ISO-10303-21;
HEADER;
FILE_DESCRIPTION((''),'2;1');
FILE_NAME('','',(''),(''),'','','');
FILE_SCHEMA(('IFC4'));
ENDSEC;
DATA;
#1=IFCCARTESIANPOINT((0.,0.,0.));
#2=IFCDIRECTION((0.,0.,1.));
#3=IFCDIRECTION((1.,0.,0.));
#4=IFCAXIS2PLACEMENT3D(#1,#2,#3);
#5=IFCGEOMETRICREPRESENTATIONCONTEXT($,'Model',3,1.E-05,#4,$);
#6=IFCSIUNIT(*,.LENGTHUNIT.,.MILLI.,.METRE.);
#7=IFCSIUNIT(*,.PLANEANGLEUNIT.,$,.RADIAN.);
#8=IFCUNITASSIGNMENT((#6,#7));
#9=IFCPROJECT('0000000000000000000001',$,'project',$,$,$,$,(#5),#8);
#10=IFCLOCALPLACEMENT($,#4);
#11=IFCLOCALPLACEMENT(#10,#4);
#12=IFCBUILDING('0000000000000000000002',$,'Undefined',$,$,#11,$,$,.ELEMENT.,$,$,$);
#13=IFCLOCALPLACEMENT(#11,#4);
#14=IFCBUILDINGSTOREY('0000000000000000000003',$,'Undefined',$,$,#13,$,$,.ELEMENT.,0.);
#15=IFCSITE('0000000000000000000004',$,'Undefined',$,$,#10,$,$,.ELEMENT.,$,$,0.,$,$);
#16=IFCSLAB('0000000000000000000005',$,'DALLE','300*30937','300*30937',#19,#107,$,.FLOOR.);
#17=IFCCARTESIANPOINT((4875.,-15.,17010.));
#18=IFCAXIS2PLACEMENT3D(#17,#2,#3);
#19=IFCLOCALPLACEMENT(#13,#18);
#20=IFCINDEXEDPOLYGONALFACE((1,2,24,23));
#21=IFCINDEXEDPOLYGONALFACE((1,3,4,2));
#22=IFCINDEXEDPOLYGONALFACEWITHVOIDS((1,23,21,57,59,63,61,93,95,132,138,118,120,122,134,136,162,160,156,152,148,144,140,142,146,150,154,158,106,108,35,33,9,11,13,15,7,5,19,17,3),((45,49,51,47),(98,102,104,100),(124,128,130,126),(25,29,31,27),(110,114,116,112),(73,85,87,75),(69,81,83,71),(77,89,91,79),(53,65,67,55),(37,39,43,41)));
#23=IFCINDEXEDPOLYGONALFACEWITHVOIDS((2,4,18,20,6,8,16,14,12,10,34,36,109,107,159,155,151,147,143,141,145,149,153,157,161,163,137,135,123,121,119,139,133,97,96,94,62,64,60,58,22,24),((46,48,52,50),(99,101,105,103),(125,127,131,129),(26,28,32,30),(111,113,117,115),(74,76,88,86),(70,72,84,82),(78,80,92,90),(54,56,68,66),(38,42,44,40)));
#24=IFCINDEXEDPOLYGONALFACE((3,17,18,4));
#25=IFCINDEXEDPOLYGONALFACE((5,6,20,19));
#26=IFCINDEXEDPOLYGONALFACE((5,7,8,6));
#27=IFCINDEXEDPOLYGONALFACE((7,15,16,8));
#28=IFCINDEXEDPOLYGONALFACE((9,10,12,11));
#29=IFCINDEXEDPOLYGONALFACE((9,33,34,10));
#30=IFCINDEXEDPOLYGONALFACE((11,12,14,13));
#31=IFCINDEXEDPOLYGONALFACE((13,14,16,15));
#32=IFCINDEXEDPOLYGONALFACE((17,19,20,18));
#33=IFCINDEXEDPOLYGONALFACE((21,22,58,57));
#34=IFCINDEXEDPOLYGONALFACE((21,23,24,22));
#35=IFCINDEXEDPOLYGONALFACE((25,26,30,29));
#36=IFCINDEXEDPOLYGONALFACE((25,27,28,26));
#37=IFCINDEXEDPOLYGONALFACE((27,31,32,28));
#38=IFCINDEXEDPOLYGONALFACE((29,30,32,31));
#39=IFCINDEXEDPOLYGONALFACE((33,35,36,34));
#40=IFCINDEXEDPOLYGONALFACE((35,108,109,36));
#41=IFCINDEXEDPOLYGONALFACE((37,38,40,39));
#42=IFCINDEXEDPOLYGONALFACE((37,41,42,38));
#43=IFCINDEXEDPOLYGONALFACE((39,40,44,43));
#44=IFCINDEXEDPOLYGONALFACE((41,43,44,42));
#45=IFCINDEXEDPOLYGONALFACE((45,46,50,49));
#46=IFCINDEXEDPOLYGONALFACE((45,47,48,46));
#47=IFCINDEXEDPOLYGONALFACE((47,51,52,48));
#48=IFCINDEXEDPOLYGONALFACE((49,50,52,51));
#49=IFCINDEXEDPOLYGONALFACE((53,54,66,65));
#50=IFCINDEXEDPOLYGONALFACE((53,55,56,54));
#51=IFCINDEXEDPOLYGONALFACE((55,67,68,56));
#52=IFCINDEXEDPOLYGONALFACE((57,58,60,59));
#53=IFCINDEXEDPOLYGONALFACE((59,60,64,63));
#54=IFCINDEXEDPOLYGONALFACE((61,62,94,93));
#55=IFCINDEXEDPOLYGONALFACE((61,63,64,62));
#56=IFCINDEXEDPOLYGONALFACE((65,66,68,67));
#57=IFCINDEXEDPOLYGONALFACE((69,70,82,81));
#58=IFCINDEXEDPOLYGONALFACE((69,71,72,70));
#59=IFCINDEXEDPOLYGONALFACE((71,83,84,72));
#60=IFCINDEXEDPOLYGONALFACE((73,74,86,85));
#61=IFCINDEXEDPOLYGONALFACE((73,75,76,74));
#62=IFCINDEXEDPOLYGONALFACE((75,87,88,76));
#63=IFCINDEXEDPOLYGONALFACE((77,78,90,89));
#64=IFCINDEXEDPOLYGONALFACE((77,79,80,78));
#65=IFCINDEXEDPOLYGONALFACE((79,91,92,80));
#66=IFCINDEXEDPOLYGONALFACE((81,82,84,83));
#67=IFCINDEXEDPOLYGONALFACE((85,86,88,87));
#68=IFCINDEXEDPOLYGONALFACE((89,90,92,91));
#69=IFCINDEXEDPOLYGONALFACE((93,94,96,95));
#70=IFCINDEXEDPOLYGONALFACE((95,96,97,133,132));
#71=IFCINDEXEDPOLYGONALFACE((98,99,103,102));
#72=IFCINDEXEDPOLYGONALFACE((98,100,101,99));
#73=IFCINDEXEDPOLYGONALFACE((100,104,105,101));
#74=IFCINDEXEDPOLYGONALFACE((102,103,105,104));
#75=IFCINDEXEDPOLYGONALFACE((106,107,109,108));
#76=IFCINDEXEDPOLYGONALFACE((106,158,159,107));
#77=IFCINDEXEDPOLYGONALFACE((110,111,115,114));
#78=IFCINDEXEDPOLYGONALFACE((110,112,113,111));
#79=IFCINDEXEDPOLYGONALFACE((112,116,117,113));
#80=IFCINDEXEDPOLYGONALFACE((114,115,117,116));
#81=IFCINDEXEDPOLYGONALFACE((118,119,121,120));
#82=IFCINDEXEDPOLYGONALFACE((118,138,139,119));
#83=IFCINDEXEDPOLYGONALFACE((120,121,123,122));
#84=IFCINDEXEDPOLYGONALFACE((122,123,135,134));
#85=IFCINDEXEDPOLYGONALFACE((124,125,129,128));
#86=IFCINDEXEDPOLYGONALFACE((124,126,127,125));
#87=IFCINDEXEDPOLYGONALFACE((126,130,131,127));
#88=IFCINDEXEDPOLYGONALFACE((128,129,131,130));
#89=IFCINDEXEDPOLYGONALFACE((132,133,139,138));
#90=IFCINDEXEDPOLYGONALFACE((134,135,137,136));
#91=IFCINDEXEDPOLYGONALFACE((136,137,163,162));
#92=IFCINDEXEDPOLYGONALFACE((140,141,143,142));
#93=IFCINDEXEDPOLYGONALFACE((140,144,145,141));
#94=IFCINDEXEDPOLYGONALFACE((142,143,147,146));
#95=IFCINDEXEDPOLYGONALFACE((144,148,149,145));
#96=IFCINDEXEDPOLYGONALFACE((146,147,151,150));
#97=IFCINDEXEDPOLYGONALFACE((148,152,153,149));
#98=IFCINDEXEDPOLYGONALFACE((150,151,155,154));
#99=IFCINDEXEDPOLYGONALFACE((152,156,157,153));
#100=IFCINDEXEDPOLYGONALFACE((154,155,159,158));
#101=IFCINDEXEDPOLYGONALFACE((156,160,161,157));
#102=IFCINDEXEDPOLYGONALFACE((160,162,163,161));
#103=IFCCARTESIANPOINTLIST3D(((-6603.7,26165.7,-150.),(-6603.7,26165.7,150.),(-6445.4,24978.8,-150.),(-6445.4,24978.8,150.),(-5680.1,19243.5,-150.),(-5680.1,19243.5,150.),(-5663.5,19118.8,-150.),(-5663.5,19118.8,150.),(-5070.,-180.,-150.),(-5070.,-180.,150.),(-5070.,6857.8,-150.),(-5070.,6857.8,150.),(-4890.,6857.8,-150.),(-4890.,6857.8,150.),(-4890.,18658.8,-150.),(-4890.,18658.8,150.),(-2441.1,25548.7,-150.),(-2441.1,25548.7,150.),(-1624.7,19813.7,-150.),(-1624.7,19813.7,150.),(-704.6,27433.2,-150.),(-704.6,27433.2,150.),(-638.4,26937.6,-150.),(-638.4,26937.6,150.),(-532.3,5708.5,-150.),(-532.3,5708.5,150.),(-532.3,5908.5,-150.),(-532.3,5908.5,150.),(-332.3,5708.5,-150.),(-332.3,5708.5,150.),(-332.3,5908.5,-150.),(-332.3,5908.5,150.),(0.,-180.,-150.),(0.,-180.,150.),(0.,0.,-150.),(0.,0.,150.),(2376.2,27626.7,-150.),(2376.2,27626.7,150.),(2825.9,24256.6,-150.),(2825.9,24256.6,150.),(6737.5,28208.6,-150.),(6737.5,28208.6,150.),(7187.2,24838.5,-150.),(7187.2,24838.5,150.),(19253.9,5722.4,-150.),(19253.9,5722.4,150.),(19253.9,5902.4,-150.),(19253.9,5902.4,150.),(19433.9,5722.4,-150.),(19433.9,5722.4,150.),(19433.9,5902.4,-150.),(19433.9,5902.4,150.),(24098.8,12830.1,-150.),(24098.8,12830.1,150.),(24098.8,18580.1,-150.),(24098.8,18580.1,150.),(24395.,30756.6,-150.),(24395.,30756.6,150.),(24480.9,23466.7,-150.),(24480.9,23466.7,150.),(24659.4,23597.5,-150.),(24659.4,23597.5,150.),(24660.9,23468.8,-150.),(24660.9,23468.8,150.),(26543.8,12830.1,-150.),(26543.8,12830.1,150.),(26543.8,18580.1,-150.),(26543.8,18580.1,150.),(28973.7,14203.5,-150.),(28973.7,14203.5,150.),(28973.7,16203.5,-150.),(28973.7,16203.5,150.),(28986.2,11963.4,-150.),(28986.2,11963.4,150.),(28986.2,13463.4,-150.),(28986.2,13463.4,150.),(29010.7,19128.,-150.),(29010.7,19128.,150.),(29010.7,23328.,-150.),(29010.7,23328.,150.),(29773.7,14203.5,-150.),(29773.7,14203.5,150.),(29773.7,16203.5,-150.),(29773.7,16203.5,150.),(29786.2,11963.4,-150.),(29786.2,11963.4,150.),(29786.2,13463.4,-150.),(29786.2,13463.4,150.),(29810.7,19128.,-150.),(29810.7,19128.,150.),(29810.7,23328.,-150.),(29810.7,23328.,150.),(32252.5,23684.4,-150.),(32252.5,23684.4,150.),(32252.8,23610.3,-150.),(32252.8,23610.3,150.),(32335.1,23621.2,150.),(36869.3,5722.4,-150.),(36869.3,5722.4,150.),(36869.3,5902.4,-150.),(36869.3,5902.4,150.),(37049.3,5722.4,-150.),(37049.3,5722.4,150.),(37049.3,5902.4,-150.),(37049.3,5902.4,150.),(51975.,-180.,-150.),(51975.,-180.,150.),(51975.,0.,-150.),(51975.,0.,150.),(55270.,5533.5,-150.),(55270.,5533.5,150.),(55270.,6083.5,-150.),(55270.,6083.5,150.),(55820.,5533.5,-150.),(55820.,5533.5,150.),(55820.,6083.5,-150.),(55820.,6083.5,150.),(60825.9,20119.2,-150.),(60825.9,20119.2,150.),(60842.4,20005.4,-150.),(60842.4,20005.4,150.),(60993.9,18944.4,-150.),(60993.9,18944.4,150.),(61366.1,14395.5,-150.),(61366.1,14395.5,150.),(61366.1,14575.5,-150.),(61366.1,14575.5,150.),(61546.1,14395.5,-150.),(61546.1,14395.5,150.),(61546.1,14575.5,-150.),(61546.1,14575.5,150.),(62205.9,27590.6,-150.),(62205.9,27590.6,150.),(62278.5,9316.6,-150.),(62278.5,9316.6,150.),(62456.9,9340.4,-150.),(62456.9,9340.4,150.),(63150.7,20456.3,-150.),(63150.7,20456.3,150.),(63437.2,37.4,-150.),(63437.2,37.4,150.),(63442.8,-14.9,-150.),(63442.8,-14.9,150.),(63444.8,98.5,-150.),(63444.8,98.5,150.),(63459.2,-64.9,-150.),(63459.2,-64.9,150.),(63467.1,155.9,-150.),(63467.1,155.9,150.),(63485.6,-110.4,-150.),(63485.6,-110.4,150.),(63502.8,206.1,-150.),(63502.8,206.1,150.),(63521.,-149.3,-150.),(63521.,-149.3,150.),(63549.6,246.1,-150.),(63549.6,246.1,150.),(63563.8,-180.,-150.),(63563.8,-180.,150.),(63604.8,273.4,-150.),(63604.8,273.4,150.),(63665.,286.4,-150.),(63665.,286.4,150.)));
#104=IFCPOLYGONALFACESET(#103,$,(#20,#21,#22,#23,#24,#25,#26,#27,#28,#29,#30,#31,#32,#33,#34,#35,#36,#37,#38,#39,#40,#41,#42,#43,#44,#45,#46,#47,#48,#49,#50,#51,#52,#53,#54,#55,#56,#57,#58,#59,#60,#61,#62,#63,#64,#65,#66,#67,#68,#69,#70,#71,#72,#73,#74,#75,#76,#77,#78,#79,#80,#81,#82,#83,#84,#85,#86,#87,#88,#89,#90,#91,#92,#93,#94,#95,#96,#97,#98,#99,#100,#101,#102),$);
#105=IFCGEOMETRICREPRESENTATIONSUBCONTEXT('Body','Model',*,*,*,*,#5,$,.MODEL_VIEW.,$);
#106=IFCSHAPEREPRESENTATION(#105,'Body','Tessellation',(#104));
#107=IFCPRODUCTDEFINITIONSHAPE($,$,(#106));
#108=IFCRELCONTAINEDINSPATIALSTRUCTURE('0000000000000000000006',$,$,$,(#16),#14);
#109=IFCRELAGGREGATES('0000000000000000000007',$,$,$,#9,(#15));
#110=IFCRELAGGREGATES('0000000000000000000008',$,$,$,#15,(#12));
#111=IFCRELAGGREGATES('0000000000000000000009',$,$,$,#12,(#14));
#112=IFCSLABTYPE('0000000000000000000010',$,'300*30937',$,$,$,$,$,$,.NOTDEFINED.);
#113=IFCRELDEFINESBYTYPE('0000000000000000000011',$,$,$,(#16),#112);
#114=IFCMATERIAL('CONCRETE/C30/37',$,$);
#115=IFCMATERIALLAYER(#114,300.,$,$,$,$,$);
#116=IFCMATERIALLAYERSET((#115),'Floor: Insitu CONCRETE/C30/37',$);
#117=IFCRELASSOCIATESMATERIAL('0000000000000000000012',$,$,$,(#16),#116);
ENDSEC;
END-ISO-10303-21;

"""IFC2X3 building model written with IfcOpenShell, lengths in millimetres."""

from ifc_helpers import new_model, si_unit, frame, origin_with_axes, origin_2d_with_axis, place, context, subcontext, project, spatial, polyline, rectangle, circle, outline, extrude, boolean, material, layer, layer_set, layer_usage, type_object, element, save


model = new_model("IFC2X3")

# Units and contexts
model_context = context("Model", 3, precision=1e-05, world=origin_with_axes())
body_context = subcontext(model_context, "Body", "Model", "MODEL_VIEW")
ifc_project = project(units=[si_unit("LENGTHUNIT", "METRE", prefix="MILLI"), si_unit("PLANEANGLEUNIT", "RADIAN")], contexts=[model_context])

# Site, building, storey
site_placement = place(None, origin_with_axes())
site = spatial("IfcSite", under=ifc_project, at=site_placement, Name="Undefined", CompositionType="ELEMENT", RefElevation=0.0)
building_placement = place(site_placement, origin_with_axes())
building = spatial("IfcBuilding", under=site, at=building_placement, Name="Undefined", CompositionType="ELEMENT")
storey_placement = place(building_placement, origin_with_axes())
storey = spatial("IfcBuildingStorey", under=building, at=storey_placement, Name="Undefined", CompositionType="ELEMENT", Elevation=0.0)

# Slab
ifc_material_1 = material(Name="CONCRETE/C30/37")
ifc_layer_1 = layer(ifc_material_1, 300.0)
ifc_layer_set_1 = layer_set([ifc_layer_1], Name="Floor: Insitu CONCRETE/C30/37")
ifc_layer_usage_1 = layer_usage(ifc_layer_set_1, "AXIS3", "POSITIVE", -150.0)
slab_type = type_object("IfcSlabType", Name="300*30937", PredefinedType="NOTDEFINED")
slab_placement = place(storey_placement, frame((4875.0, -15.0, 17010.0), z_axis=(0.0, 0.0, 1.0), x_axis=(1.0, 0.0, 0.0)))
solid = boolean("DIFFERENCE", boolean("DIFFERENCE", boolean("DIFFERENCE", boolean("DIFFERENCE", boolean("DIFFERENCE", boolean("DIFFERENCE", boolean("DIFFERENCE", boolean("DIFFERENCE", extrude(outline(polyline([(0.0, 0.0), (51975.0, 0.0), (51975.0, -180.0), (63727.2, -180.0), (62456.9, 9340.4), (62278.5, 9316.6), (60993.9, 18944.4), (60842.4, 20005.4), (60825.9, 20119.2), (63150.7, 20456.3), (62205.9, 27590.6), (32335.1, 23621.2), (32252.8, 23610.3), (32252.5, 23684.4), (24659.4, 23597.5), (24660.9, 23468.8), (24480.9, 23466.7), (24395.0, 30756.6), (-704.6, 27433.2), (-638.4, 26937.6), (-6603.7, 26165.7), (-6445.4, 24978.8), (-2441.1, 25548.7), (-1624.7, 19813.7), (-5680.1, 19243.5), (-5663.5, 19118.8), (-4890.0, 18658.8), (-4890.0, 6857.8), (-5070.0, 6857.8), (-5070.0, -180.0), (0.0, -180.0), (0.0, 0.0)])), frame((0.0, 0.0, -150.0), z_axis=(0.0, 0.0, 1.0), x_axis=(1.0, 0.0, 0.0)), (0.0, 0.0, 1.0), 300.0), extrude(rectangle(XDim=180.0, YDim=180.0, at=origin_2d_with_axis()), frame((61456.1, 14485.5, 160.0), z_axis=(0.0, 0.0, -1.0), x_axis=(-1.0, 0.0, 0.0)), (0.0, 0.0, 1.0), 320.0)), extrude(rectangle(XDim=550.0, YDim=550.0, at=origin_2d_with_axis()), frame((55545.0, 5808.5, 160.0), z_axis=(0.0, 0.0, -1.0), x_axis=(-1.0, 0.0, 0.0)), (0.0, 0.0, 1.0), 320.0)), extrude(rectangle(XDim=180.0, YDim=180.0, at=origin_2d_with_axis()), frame((36959.3, 5812.4, 160.0), z_axis=(0.0, 0.0, -1.0), x_axis=(-1.0, 0.0, 0.0)), (0.0, 0.0, 1.0), 320.0)), extrude(rectangle(XDim=180.0, YDim=180.0, at=origin_2d_with_axis()), frame((19343.9, 5812.4, 160.0), z_axis=(0.0, 0.0, -1.0), x_axis=(-1.0, 0.0, 0.0)), (0.0, 0.0, 1.0), 320.0)), extrude(rectangle(XDim=200.0, YDim=200.0, at=origin_2d_with_axis()), frame((-432.3, 5808.5, 160.0), z_axis=(0.0, 0.0, -1.0), x_axis=(-1.0, 0.0, 0.0)), (0.0, 0.0, 1.0), 320.0)), extrude(rectangle(XDim=800.0, YDim=1500.0, at=origin_2d_with_axis()), frame((29386.2, 12713.4, 160.0), z_axis=(0.0, 0.0, -1.0), x_axis=(-1.0, 0.0, 0.0)), (0.0, 0.0, 1.0), 320.0)), extrude(rectangle(XDim=800.0, YDim=2000.0, at=origin_2d_with_axis()), frame((29373.7, 15203.5, 160.0), z_axis=(0.0, 0.0, -1.0), x_axis=(-1.0, 0.0, 0.0)), (0.0, 0.0, 1.0), 320.0)), extrude(rectangle(XDim=800.0, YDim=4200.0, at=origin_2d_with_axis()), frame((29410.7, 21228.0, 160.0), z_axis=(0.0, 0.0, -1.0), x_axis=(-1.0, 0.0, 0.0)), (0.0, 0.0, 1.0), 320.0))
element("IfcSlab", 1, at=slab_placement, inside=storey, type_object=slab_type, material=ifc_layer_usage_1, Name="DALLE", Description="300*30937", ObjectType="300*30937", PredefinedType="FLOOR", context=body_context, shape_type="CSG", body=[
    boolean("DIFFERENCE", boolean("DIFFERENCE", boolean("DIFFERENCE", solid, extrude(circle(Radius=250.0, at=origin_2d_with_axis()), frame((63687.2, 37.4, 1875.0), z_axis=(0.0, 0.0, -1.0), x_axis=(-1.0, 0.0, 0.0)), (0.0, 0.0, 1.0), 10000.0)), extrude(outline(polyline([(0.0, 0.0), (5750.0, 0.0), (5750.0, 2445.0), (0.0, 2445.0), (0.0, 0.0)])), frame((24098.8, 18580.1, -252.5), z_axis=(0.0, 0.0, 1.0), x_axis=(0.0, -1.0, 0.0)), (0.0, 0.0, 1.0), 405.0)), extrude(outline(polyline([(0.0, 0.0), (4400.0, 0.0), (4400.0, 3400.0), (0.0, 3400.0), (0.0, 0.0)])), frame((2376.2, 27626.7, 152.5), z_axis=(0.0, 0.0, -1.0), x_axis=(0.991216, 0.132256, 0.0)), (0.0, 0.0, 1.0), 405.0)),
])

save(model, "model.ifc")
